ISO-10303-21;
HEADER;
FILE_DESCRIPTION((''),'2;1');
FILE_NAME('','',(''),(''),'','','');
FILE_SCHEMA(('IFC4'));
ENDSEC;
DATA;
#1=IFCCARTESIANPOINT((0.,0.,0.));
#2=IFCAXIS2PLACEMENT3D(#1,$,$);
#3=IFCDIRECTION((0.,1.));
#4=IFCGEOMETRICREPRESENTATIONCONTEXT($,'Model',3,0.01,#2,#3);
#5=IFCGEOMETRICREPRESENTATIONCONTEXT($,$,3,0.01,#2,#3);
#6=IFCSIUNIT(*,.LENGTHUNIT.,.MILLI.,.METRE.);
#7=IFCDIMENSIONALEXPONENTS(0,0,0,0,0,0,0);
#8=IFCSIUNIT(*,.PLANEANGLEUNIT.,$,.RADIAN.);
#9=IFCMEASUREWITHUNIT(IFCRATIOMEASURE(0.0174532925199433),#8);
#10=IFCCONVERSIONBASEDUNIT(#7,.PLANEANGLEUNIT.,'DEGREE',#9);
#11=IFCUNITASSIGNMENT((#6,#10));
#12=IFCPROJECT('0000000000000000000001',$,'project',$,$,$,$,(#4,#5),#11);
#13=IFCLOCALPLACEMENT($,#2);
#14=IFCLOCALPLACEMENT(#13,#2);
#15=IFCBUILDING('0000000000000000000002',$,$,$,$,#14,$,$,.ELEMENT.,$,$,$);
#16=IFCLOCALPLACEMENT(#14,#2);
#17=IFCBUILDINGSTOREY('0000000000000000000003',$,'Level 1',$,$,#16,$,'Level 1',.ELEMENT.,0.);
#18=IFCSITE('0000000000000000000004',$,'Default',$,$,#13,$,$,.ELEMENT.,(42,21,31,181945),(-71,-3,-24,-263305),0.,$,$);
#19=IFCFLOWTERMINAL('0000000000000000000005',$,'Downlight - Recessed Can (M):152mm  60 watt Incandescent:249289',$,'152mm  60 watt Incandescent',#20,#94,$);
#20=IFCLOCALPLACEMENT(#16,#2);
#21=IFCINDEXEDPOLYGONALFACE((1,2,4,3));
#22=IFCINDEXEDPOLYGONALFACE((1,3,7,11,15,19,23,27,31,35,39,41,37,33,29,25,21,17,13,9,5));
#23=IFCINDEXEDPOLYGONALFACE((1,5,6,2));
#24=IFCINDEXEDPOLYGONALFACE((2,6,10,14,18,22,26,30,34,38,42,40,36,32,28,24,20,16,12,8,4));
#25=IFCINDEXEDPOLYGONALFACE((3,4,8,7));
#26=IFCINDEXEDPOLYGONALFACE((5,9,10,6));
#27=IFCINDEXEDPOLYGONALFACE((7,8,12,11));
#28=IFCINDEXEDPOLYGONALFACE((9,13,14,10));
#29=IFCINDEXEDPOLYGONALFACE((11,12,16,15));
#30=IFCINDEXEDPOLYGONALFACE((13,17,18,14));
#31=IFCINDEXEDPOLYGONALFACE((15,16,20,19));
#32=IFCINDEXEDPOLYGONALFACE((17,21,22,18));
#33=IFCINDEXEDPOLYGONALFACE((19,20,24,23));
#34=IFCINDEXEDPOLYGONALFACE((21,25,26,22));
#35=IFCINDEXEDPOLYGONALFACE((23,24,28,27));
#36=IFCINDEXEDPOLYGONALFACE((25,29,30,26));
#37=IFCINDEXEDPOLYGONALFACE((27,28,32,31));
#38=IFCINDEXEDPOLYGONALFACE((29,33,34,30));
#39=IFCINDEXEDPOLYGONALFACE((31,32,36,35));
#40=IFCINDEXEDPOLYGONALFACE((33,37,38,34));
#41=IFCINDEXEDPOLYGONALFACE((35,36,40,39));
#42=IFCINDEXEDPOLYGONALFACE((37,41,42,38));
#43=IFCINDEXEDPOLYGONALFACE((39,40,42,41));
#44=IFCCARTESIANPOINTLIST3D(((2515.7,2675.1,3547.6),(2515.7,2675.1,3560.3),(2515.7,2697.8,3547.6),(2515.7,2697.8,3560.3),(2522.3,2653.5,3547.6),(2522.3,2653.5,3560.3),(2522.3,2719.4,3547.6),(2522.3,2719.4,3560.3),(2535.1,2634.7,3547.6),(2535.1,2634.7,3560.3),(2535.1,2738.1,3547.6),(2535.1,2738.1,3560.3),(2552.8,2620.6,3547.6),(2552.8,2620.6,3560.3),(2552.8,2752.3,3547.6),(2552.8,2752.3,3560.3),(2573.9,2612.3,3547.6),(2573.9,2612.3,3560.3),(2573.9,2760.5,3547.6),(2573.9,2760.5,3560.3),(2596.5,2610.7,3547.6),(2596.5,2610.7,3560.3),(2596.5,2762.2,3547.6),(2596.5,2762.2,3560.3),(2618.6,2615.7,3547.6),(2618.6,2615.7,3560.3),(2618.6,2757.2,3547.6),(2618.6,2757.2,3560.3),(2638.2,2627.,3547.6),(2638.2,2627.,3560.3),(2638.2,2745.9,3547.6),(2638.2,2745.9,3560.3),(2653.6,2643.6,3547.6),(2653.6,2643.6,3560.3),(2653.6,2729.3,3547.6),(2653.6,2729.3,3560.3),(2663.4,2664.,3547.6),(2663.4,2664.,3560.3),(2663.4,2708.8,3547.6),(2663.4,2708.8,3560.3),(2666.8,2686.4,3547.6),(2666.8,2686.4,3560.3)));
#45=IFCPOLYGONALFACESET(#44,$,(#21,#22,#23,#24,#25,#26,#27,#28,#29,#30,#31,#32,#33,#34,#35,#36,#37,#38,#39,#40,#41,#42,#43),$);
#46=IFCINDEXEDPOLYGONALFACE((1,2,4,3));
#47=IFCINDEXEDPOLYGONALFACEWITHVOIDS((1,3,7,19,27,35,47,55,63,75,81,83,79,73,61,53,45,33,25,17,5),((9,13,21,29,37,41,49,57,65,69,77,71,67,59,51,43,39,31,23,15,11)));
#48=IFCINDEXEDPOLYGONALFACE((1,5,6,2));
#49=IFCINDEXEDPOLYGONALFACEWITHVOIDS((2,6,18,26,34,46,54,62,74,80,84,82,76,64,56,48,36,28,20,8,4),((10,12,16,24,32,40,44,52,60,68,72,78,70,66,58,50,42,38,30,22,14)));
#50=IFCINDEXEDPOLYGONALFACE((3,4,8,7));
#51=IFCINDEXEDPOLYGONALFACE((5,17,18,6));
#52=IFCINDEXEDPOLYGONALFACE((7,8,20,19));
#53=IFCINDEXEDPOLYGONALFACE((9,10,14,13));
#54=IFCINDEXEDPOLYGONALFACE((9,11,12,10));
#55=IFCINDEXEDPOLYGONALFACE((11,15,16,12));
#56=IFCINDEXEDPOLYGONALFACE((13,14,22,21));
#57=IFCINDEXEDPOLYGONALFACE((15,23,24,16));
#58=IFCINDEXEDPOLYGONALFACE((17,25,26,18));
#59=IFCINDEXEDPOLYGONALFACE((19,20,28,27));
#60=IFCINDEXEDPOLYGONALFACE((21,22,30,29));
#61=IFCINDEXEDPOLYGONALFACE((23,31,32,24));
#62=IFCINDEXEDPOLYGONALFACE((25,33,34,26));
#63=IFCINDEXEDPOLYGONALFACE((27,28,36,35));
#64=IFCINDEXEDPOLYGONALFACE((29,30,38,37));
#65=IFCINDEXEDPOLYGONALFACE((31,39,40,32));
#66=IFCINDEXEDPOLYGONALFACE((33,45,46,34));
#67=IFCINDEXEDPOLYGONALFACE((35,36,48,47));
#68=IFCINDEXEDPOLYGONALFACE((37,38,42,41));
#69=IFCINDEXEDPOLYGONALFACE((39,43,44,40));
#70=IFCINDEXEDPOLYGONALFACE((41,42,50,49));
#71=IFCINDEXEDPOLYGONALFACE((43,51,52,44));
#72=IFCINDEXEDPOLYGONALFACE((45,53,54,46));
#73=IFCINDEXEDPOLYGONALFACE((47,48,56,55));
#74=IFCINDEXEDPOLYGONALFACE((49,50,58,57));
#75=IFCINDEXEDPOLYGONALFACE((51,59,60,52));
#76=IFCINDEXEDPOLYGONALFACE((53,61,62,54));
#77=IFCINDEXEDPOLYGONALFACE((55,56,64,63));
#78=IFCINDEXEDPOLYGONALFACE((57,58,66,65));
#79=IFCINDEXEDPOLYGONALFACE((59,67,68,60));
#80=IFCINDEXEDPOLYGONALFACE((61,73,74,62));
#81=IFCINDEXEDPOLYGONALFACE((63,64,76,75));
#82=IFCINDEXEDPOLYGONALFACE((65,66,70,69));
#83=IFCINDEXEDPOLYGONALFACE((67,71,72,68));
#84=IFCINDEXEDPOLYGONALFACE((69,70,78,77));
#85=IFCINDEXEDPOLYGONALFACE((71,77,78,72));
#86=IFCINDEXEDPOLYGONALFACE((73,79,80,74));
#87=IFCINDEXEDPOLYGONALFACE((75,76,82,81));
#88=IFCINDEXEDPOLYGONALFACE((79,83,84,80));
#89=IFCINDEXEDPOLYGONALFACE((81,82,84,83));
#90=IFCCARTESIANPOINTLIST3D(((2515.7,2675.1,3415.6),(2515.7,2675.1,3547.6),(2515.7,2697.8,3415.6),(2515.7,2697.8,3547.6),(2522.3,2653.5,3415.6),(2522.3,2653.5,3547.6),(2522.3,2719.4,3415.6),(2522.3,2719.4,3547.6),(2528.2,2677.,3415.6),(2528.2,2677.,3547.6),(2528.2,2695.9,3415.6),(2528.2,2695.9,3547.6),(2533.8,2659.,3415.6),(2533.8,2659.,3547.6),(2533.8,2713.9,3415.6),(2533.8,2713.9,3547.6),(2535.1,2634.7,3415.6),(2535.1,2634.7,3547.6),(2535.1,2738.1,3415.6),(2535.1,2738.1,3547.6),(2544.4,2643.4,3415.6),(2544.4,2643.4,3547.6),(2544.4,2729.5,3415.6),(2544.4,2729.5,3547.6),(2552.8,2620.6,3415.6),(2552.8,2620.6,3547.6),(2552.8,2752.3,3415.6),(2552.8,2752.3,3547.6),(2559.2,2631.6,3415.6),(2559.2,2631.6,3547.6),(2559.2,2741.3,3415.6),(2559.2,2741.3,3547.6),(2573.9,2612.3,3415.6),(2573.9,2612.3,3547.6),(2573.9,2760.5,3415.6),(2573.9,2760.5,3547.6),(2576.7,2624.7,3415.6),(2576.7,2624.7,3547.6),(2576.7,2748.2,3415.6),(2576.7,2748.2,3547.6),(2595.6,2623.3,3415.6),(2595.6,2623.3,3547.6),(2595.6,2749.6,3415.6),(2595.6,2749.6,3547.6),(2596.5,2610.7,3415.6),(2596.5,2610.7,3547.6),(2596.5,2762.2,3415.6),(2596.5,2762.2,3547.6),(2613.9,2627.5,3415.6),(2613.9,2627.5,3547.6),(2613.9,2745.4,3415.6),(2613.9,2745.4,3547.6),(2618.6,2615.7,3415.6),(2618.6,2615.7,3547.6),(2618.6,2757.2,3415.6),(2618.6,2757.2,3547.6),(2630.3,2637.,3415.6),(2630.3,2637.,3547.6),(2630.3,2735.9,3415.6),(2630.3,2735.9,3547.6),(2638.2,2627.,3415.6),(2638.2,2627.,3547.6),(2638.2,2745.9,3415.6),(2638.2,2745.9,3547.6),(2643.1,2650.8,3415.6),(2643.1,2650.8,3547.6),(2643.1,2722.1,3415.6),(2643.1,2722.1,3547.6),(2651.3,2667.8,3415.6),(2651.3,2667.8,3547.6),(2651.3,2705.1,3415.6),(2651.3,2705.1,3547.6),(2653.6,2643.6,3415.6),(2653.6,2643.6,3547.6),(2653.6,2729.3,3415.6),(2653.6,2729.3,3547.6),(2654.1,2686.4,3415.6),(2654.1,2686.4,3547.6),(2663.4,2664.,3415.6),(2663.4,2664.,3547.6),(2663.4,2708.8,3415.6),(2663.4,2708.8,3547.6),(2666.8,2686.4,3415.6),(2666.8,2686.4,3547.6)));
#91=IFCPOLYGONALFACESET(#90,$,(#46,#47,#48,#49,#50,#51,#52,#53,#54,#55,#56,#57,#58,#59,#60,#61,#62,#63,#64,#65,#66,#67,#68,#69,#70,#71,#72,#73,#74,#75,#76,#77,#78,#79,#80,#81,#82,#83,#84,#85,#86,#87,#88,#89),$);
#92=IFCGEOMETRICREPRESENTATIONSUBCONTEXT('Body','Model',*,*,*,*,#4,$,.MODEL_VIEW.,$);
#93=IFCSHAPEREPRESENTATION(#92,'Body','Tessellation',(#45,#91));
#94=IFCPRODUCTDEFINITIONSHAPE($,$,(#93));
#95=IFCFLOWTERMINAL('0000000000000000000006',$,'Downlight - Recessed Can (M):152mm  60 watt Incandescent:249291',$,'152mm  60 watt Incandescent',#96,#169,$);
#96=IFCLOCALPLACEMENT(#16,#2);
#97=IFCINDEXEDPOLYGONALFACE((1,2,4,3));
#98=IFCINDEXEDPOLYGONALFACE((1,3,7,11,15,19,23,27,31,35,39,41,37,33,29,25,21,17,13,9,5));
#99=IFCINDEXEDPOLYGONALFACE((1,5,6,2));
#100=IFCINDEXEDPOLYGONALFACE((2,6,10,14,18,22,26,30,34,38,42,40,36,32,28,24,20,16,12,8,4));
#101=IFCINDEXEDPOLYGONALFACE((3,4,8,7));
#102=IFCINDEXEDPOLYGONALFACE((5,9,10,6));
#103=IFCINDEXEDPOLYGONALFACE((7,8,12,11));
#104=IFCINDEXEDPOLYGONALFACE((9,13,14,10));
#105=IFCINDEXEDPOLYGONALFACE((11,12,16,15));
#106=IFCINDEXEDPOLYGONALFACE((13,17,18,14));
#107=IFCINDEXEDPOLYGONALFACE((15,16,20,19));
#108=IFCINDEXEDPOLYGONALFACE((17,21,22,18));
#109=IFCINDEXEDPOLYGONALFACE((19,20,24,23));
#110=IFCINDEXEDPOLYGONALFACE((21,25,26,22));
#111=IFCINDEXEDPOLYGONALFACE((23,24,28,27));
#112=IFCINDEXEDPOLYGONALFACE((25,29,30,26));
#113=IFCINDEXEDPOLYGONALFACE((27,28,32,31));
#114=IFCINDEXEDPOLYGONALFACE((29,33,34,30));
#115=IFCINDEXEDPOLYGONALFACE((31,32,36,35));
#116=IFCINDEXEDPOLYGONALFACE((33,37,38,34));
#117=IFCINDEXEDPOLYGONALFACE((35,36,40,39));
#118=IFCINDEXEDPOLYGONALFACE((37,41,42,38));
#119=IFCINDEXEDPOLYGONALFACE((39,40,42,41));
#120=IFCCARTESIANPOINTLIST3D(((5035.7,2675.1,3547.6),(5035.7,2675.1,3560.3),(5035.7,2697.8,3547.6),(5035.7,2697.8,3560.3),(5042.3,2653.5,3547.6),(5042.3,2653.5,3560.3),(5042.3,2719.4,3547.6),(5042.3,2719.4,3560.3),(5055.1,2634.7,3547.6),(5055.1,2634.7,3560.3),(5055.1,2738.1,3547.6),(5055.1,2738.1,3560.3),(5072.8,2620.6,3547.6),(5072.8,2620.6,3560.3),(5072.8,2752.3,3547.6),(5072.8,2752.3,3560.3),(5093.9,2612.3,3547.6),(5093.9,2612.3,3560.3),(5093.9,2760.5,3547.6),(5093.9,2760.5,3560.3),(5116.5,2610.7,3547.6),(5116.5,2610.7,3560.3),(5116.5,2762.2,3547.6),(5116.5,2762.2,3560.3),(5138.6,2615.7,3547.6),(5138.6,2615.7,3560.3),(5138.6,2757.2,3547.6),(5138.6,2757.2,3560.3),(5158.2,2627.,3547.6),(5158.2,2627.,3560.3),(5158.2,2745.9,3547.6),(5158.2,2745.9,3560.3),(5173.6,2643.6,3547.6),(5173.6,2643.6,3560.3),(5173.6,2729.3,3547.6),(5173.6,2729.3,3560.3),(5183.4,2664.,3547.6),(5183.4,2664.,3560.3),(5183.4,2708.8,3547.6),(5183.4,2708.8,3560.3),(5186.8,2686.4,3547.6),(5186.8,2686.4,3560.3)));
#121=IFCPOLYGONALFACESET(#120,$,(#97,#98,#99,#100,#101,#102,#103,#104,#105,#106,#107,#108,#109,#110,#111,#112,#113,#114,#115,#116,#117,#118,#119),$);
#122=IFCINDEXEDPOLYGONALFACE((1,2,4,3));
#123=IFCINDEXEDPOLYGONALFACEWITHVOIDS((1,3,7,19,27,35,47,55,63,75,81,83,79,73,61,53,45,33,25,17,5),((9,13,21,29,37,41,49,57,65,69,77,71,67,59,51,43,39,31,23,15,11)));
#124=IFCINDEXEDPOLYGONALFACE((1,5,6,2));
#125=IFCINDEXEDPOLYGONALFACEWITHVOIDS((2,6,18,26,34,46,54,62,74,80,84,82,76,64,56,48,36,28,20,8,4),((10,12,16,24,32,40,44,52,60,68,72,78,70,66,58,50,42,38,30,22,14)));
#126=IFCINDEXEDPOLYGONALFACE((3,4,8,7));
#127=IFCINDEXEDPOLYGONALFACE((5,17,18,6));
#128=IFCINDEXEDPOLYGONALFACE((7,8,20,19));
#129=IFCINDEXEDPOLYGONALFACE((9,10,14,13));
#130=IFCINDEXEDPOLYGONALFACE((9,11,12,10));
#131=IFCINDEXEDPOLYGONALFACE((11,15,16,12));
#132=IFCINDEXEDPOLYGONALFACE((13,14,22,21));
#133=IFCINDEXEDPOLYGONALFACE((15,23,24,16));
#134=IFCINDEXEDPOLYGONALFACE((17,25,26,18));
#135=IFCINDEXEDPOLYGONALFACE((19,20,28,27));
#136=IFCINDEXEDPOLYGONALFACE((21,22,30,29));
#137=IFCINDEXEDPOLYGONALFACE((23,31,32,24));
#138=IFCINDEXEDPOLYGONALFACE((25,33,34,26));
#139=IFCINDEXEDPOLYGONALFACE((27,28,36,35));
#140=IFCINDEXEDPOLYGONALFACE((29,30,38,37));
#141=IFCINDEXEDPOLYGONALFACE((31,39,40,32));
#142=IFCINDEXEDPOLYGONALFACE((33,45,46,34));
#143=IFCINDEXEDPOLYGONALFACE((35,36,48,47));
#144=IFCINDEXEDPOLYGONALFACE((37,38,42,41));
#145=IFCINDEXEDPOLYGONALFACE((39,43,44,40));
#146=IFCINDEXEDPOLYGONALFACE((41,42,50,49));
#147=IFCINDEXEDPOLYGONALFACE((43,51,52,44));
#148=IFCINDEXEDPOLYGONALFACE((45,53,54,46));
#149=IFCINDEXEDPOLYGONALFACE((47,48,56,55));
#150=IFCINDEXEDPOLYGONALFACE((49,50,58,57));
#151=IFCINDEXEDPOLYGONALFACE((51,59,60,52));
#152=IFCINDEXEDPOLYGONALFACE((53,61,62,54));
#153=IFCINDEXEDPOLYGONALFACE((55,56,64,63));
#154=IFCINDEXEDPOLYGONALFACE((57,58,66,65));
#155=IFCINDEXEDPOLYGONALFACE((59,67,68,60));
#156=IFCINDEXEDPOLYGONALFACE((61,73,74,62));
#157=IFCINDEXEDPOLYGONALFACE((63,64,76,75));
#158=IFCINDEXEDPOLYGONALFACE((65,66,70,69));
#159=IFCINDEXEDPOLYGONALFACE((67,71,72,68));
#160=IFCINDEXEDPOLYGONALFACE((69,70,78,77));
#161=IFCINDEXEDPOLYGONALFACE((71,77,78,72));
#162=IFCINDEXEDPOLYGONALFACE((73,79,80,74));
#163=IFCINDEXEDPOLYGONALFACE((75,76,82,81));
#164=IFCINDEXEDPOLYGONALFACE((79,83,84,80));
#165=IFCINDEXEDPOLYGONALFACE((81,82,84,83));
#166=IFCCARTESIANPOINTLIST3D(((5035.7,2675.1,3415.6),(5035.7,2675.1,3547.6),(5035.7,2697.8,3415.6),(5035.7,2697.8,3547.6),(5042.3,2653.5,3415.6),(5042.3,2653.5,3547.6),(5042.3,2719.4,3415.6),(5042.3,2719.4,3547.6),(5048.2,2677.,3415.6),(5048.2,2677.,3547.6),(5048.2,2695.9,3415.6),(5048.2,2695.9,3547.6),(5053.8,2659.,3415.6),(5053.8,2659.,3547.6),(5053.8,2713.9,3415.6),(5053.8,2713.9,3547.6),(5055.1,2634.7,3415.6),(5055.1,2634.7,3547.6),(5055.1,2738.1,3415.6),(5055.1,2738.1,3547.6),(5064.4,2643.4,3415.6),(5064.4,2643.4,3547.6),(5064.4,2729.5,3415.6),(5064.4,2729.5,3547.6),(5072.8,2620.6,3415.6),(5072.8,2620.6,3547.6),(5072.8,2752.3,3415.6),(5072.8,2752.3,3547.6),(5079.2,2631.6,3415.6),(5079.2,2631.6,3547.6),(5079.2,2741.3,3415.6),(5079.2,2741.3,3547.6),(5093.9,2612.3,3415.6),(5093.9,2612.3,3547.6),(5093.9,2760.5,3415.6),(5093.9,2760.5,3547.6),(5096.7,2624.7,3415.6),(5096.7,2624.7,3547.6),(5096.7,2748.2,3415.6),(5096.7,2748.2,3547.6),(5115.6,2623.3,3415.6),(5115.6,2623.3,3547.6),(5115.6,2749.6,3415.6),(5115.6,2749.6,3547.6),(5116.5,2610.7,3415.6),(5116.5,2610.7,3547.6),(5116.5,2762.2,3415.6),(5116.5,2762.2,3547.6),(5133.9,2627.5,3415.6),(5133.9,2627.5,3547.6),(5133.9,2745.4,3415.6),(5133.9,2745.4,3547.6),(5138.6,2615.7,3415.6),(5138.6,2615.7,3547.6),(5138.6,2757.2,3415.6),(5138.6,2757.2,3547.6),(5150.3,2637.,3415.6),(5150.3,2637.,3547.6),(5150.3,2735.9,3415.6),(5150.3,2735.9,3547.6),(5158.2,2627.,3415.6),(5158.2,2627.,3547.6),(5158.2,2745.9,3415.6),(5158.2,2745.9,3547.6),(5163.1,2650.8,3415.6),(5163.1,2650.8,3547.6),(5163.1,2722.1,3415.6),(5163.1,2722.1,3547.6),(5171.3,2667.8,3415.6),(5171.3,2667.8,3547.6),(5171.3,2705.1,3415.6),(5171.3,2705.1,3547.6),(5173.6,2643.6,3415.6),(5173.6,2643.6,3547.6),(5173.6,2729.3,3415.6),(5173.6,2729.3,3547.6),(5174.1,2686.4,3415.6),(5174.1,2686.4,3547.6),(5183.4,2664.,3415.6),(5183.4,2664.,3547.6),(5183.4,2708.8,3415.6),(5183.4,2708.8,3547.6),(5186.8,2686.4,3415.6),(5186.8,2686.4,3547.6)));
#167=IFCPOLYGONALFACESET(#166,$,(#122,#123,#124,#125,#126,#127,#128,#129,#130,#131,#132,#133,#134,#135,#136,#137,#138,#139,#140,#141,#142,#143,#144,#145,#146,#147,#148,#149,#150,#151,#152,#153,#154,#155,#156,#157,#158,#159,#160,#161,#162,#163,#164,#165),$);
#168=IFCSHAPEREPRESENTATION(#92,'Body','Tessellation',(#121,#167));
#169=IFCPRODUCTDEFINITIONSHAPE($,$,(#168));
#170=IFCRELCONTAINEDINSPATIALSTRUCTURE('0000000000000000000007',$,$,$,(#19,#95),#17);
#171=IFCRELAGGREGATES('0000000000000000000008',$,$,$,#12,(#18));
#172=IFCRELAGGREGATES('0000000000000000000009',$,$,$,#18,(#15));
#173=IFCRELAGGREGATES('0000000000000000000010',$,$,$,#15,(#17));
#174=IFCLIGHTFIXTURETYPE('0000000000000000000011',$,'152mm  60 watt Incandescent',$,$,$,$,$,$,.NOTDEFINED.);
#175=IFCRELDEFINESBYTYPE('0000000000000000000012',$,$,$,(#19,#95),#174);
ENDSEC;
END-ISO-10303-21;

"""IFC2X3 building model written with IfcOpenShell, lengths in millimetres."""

from ifc_helpers import new_model, entity, si_unit, converted_unit, direction, frame, frame_2d, origin, place, context, subcontext, project, spatial, circle, hollow_circle, extrude, source, transform, mapped, type_object, type_shapes, element, save


model = new_model("IFC2X3")

# Units and contexts
model_context = context("Model", 3, precision=0.01, world=origin(), true_north=direction((0.0, 1.0)))
context_of_model = context(None, 3, precision=0.01, world=origin(), true_north=direction((0.0, 1.0)))
body_context = subcontext(model_context, "Body", "Model", "MODEL_VIEW")
ifc_project = project(units=[si_unit("LENGTHUNIT", "METRE", prefix="MILLI"), converted_unit("PLANEANGLEUNIT", "DEGREE", entity("IfcRatioMeasure", 0.0174532925199433), si_unit("PLANEANGLEUNIT", "RADIAN"), dimensions=[0, 0, 0, 0, 0, 0, 0])], contexts=[model_context, context_of_model])

# Site, building, storey
site_placement = place(None, origin())
site = spatial("IfcSite", under=ifc_project, at=site_placement, Name="Default", CompositionType="ELEMENT", RefLatitude=(42, 21, 31, 181945), RefLongitude=(-71, -3, -24, -263305), RefElevation=0.0)
building_placement = place(site_placement, origin())
building = spatial("IfcBuilding", under=site, at=building_placement, CompositionType="ELEMENT")
storey_placement = place(building_placement, origin())
storey = spatial("IfcBuildingStorey", under=building, at=storey_placement, Name="Level 1", LongName="Level 1", CompositionType="ELEMENT", Elevation=0.0)

# Flow terminals
light_fixture_type_1 = type_object("IfcLightFixtureType", Name="152mm  60 watt Incandescent", PredefinedType="NOTDEFINED")
shared_shape_1 = source(origin(), body_context, "Body", "SweptSolid", [
    extrude(circle(Radius=76.0, at=frame_2d((0.0, 0.0), x_axis=(1.0, 0.0))), frame((0.0, 0.0, 2628.7)), (0.0, 0.0, 1.0), 12.7),
    extrude(hollow_circle(Radius=76.0, WallThickness=12.7, at=frame_2d((0.0, 0.0), x_axis=(1.0, 0.0))), frame((0.0, 0.0, 2496.7)), (0.0, 0.0, 1.0), 132.0),
])
type_shapes(light_fixture_type_1, [shared_shape_1])
for number, where, name in (
    (1, (2590.8, 2686.4, 918.9), "Downlight - Recessed Can (M):152mm  60 watt Incandescent:249289"),
    (2, (5110.8, 2686.4, 918.9), "Downlight - Recessed Can (M):152mm  60 watt Incandescent:249291"),
):
    element("IfcFlowTerminal", number, at=place(storey_placement, frame(where)), inside=storey, type_object=light_fixture_type_1, Name=name, ObjectType="152mm  60 watt Incandescent", context=body_context, shape_type="MappedRepresentation", body=[
        mapped(shared_shape_1, transform((0.0, 0.0, 0.0), scale=1.0)),
    ])

save(model, "model.ifc")
